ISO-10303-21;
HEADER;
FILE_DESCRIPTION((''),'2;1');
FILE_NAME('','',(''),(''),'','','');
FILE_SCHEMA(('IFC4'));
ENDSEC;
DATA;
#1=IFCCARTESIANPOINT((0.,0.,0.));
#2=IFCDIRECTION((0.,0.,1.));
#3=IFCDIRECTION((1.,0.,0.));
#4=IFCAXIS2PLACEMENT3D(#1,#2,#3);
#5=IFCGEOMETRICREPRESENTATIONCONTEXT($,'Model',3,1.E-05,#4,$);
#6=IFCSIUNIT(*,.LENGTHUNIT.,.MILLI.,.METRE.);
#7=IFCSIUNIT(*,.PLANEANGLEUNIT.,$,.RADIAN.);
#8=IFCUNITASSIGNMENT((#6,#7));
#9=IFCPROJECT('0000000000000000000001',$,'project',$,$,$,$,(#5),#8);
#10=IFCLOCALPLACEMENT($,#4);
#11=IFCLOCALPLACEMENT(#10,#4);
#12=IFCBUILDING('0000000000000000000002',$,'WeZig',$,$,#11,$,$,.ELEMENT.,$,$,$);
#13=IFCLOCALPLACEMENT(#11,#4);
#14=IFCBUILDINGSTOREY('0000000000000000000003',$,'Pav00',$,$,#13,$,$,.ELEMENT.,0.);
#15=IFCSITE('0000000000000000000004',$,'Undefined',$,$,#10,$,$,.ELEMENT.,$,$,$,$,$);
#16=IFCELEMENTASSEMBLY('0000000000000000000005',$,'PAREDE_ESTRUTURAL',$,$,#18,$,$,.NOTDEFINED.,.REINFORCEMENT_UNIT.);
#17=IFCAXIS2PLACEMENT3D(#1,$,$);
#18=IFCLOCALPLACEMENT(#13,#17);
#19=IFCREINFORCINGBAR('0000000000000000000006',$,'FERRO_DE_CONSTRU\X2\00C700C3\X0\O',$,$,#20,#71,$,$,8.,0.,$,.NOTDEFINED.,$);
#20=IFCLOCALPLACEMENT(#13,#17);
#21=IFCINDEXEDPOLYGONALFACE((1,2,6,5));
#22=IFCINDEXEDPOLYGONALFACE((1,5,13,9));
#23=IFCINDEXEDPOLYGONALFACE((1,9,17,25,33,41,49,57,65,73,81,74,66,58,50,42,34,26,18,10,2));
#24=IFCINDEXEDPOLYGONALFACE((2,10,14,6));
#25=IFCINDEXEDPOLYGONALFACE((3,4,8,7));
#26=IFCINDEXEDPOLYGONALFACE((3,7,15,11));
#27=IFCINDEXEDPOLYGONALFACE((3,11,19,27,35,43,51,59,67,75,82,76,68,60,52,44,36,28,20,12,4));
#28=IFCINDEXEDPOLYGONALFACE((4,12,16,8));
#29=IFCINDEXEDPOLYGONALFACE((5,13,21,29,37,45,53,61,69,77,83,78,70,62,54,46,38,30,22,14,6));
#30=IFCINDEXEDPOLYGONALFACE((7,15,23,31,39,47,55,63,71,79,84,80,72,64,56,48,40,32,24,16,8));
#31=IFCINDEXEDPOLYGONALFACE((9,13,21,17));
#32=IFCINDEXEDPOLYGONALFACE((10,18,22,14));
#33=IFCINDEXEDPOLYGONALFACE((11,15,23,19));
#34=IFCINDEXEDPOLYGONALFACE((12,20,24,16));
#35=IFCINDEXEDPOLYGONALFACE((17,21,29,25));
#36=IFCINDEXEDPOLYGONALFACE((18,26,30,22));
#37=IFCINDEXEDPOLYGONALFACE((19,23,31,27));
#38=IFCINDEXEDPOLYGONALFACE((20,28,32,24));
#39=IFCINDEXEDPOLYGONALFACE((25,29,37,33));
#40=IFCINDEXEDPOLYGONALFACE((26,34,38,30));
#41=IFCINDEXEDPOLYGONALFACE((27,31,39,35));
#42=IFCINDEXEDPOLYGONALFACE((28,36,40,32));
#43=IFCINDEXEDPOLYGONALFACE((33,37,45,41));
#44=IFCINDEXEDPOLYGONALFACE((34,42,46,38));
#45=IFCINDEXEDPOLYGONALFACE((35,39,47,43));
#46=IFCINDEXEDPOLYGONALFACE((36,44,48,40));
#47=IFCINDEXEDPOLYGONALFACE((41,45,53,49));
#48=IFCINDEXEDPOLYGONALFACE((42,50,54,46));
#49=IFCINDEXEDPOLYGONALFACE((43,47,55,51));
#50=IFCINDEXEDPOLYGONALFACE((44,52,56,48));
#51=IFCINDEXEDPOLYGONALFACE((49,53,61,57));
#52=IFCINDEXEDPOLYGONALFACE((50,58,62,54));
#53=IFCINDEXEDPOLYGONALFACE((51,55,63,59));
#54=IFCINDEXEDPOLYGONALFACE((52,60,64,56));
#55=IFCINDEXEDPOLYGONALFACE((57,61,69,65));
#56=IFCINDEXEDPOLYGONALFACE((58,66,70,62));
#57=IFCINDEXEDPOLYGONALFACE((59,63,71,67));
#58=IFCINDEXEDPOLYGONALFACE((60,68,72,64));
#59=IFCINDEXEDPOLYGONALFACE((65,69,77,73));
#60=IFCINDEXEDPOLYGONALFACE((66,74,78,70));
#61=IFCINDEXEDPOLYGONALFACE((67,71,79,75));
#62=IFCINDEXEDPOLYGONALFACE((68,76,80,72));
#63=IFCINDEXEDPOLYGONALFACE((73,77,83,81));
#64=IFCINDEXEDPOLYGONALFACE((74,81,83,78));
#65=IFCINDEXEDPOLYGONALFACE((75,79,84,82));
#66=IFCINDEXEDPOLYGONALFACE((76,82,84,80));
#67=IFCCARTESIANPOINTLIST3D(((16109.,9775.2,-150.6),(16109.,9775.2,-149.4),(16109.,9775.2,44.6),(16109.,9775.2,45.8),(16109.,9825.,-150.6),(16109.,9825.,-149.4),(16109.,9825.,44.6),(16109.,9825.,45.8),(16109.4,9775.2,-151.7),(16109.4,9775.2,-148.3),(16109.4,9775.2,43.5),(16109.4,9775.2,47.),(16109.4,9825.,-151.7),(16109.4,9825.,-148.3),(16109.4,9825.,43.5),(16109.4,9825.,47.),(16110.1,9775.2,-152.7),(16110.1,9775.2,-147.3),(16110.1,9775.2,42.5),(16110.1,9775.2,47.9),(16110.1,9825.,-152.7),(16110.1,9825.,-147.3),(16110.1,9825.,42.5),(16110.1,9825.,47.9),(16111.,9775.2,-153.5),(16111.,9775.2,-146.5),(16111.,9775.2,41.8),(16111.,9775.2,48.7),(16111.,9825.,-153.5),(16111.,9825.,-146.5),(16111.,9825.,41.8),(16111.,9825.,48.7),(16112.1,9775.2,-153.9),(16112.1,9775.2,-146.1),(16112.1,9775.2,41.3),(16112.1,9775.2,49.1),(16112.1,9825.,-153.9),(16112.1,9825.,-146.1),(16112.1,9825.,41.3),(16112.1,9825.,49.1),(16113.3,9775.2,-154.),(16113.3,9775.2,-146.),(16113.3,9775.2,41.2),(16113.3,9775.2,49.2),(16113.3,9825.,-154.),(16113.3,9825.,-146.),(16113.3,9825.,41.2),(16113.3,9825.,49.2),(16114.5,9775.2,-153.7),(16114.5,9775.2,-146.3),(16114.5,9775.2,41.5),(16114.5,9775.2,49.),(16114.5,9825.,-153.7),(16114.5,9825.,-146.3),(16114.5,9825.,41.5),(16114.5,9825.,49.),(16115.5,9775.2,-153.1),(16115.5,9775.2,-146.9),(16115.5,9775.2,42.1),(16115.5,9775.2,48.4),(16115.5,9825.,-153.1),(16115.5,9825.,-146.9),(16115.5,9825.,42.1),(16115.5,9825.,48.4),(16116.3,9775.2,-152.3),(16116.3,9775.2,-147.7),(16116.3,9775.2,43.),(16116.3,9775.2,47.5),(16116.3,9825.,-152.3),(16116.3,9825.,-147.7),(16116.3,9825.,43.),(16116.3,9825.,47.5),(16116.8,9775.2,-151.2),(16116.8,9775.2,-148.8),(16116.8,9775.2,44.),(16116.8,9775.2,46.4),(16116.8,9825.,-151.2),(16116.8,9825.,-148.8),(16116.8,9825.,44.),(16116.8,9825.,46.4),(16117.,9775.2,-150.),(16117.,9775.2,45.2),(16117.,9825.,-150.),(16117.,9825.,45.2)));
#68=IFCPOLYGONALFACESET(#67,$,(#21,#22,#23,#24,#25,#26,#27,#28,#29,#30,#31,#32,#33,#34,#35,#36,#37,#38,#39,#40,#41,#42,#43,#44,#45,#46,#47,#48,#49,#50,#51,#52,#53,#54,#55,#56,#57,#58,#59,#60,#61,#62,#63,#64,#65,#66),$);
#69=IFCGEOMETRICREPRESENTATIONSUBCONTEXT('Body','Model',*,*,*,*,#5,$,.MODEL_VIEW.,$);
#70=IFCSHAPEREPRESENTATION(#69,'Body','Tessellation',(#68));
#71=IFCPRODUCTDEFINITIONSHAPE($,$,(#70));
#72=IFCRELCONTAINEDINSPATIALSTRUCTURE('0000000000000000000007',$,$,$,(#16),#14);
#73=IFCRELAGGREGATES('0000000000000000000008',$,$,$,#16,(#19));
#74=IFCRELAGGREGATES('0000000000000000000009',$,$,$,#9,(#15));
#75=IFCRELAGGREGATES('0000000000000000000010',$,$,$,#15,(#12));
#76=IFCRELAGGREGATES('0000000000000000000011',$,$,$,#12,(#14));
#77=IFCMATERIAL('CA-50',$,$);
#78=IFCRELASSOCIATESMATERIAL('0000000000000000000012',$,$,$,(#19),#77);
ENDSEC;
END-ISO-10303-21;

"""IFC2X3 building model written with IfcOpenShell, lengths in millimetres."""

from ifc_helpers import new_model, entity, si_unit, frame, origin_with_axes, place, context, subcontext, project, spatial, source, transform, mapped, material, element, aggregate, save


model = new_model("IFC2X3")

# Units and contexts
model_context = context("Model", 3, precision=1e-05, world=origin_with_axes())
body_context = subcontext(model_context, "Body", "Model", "MODEL_VIEW")
ifc_project = project(units=[si_unit("LENGTHUNIT", "METRE", prefix="MILLI"), si_unit("PLANEANGLEUNIT", "RADIAN")], contexts=[model_context])

# Site, building, storey
site_placement = place(None, origin_with_axes())
site = spatial("IfcSite", under=ifc_project, at=site_placement, Name="Undefined", CompositionType="ELEMENT")
building_placement = place(site_placement, origin_with_axes())
building = spatial("IfcBuilding", under=site, at=building_placement, Name="WeZig", CompositionType="ELEMENT")
storey_placement = place(building_placement, origin_with_axes())
storey = spatial("IfcBuildingStorey", under=building, at=storey_placement, Name="Pav00", CompositionType="ELEMENT", Elevation=0.0)

# Element assembly
assembly_1_placement = place(storey_placement, origin_with_axes())
assembly_1 = element("IfcElementAssembly", 1, at=assembly_1_placement, inside=storey, Name="PAREDE_ESTRUTURAL", AssemblyPlace="NOTDEFINED", PredefinedType="REINFORCEMENT_UNIT")

# Reinforcing bar
ifc_material_1 = material(Name="CA-50")
shared_shape_1 = source(origin_with_axes(), body_context, "Body", "AdvancedSweptSolid", [
    entity("IfcSweptDiskSolid", entity("IfcTrimmedCurve", entity("IfcLine", entity("IfcCartesianPoint", [0.0, 0.0, 0.0]), entity("IfcVector", entity("IfcDirection", [1.0, 0.0, 0.0]), 1.0)), [entity("IfcParameterValue", 0.0)], [entity("IfcParameterValue", 49.805158)], True, "PARAMETER"), 4.0, None, 0.0, 49.8),
])
shared_shape_2 = source(origin_with_axes(), body_context, "Body", "AdvancedSweptSolid", [
    entity("IfcSweptDiskSolid", entity("IfcTrimmedCurve", entity("IfcLine", entity("IfcCartesianPoint", [0.0, 0.0, 0.0]), entity("IfcVector", entity("IfcDirection", [1.0, 0.0, 0.0]), 1.0)), [entity("IfcParameterValue", 0.0)], [entity("IfcParameterValue", 49.805158)], True, "PARAMETER"), 4.0, None, 0.0, 49.8),
])
reinforcing_bar_1_placement = place(assembly_1_placement, frame((16113.0, 9825.0, 45.2), z_axis=(1.0, 0.0, 0.0), x_axis=(0.0, -1.0, 0.0)))
reinforcing_bar_1 = element("IfcReinforcingBar", 2, at=reinforcing_bar_1_placement, material=ifc_material_1, Name="FERRO_DE_CONSTRUÇÃO", BarRole="NOTDEFINED", CrossSectionArea=0.0, NominalDiameter=8.0, context=body_context, shape_type="MappedRepresentation", body=[
    mapped(shared_shape_1, transform((0.0, 0.0, 0.0))),
    mapped(shared_shape_2, transform((0.0, 195.2, 0.0))),
])
aggregate(assembly_1, [reinforcing_bar_1])

save(model, "model.ifc")
